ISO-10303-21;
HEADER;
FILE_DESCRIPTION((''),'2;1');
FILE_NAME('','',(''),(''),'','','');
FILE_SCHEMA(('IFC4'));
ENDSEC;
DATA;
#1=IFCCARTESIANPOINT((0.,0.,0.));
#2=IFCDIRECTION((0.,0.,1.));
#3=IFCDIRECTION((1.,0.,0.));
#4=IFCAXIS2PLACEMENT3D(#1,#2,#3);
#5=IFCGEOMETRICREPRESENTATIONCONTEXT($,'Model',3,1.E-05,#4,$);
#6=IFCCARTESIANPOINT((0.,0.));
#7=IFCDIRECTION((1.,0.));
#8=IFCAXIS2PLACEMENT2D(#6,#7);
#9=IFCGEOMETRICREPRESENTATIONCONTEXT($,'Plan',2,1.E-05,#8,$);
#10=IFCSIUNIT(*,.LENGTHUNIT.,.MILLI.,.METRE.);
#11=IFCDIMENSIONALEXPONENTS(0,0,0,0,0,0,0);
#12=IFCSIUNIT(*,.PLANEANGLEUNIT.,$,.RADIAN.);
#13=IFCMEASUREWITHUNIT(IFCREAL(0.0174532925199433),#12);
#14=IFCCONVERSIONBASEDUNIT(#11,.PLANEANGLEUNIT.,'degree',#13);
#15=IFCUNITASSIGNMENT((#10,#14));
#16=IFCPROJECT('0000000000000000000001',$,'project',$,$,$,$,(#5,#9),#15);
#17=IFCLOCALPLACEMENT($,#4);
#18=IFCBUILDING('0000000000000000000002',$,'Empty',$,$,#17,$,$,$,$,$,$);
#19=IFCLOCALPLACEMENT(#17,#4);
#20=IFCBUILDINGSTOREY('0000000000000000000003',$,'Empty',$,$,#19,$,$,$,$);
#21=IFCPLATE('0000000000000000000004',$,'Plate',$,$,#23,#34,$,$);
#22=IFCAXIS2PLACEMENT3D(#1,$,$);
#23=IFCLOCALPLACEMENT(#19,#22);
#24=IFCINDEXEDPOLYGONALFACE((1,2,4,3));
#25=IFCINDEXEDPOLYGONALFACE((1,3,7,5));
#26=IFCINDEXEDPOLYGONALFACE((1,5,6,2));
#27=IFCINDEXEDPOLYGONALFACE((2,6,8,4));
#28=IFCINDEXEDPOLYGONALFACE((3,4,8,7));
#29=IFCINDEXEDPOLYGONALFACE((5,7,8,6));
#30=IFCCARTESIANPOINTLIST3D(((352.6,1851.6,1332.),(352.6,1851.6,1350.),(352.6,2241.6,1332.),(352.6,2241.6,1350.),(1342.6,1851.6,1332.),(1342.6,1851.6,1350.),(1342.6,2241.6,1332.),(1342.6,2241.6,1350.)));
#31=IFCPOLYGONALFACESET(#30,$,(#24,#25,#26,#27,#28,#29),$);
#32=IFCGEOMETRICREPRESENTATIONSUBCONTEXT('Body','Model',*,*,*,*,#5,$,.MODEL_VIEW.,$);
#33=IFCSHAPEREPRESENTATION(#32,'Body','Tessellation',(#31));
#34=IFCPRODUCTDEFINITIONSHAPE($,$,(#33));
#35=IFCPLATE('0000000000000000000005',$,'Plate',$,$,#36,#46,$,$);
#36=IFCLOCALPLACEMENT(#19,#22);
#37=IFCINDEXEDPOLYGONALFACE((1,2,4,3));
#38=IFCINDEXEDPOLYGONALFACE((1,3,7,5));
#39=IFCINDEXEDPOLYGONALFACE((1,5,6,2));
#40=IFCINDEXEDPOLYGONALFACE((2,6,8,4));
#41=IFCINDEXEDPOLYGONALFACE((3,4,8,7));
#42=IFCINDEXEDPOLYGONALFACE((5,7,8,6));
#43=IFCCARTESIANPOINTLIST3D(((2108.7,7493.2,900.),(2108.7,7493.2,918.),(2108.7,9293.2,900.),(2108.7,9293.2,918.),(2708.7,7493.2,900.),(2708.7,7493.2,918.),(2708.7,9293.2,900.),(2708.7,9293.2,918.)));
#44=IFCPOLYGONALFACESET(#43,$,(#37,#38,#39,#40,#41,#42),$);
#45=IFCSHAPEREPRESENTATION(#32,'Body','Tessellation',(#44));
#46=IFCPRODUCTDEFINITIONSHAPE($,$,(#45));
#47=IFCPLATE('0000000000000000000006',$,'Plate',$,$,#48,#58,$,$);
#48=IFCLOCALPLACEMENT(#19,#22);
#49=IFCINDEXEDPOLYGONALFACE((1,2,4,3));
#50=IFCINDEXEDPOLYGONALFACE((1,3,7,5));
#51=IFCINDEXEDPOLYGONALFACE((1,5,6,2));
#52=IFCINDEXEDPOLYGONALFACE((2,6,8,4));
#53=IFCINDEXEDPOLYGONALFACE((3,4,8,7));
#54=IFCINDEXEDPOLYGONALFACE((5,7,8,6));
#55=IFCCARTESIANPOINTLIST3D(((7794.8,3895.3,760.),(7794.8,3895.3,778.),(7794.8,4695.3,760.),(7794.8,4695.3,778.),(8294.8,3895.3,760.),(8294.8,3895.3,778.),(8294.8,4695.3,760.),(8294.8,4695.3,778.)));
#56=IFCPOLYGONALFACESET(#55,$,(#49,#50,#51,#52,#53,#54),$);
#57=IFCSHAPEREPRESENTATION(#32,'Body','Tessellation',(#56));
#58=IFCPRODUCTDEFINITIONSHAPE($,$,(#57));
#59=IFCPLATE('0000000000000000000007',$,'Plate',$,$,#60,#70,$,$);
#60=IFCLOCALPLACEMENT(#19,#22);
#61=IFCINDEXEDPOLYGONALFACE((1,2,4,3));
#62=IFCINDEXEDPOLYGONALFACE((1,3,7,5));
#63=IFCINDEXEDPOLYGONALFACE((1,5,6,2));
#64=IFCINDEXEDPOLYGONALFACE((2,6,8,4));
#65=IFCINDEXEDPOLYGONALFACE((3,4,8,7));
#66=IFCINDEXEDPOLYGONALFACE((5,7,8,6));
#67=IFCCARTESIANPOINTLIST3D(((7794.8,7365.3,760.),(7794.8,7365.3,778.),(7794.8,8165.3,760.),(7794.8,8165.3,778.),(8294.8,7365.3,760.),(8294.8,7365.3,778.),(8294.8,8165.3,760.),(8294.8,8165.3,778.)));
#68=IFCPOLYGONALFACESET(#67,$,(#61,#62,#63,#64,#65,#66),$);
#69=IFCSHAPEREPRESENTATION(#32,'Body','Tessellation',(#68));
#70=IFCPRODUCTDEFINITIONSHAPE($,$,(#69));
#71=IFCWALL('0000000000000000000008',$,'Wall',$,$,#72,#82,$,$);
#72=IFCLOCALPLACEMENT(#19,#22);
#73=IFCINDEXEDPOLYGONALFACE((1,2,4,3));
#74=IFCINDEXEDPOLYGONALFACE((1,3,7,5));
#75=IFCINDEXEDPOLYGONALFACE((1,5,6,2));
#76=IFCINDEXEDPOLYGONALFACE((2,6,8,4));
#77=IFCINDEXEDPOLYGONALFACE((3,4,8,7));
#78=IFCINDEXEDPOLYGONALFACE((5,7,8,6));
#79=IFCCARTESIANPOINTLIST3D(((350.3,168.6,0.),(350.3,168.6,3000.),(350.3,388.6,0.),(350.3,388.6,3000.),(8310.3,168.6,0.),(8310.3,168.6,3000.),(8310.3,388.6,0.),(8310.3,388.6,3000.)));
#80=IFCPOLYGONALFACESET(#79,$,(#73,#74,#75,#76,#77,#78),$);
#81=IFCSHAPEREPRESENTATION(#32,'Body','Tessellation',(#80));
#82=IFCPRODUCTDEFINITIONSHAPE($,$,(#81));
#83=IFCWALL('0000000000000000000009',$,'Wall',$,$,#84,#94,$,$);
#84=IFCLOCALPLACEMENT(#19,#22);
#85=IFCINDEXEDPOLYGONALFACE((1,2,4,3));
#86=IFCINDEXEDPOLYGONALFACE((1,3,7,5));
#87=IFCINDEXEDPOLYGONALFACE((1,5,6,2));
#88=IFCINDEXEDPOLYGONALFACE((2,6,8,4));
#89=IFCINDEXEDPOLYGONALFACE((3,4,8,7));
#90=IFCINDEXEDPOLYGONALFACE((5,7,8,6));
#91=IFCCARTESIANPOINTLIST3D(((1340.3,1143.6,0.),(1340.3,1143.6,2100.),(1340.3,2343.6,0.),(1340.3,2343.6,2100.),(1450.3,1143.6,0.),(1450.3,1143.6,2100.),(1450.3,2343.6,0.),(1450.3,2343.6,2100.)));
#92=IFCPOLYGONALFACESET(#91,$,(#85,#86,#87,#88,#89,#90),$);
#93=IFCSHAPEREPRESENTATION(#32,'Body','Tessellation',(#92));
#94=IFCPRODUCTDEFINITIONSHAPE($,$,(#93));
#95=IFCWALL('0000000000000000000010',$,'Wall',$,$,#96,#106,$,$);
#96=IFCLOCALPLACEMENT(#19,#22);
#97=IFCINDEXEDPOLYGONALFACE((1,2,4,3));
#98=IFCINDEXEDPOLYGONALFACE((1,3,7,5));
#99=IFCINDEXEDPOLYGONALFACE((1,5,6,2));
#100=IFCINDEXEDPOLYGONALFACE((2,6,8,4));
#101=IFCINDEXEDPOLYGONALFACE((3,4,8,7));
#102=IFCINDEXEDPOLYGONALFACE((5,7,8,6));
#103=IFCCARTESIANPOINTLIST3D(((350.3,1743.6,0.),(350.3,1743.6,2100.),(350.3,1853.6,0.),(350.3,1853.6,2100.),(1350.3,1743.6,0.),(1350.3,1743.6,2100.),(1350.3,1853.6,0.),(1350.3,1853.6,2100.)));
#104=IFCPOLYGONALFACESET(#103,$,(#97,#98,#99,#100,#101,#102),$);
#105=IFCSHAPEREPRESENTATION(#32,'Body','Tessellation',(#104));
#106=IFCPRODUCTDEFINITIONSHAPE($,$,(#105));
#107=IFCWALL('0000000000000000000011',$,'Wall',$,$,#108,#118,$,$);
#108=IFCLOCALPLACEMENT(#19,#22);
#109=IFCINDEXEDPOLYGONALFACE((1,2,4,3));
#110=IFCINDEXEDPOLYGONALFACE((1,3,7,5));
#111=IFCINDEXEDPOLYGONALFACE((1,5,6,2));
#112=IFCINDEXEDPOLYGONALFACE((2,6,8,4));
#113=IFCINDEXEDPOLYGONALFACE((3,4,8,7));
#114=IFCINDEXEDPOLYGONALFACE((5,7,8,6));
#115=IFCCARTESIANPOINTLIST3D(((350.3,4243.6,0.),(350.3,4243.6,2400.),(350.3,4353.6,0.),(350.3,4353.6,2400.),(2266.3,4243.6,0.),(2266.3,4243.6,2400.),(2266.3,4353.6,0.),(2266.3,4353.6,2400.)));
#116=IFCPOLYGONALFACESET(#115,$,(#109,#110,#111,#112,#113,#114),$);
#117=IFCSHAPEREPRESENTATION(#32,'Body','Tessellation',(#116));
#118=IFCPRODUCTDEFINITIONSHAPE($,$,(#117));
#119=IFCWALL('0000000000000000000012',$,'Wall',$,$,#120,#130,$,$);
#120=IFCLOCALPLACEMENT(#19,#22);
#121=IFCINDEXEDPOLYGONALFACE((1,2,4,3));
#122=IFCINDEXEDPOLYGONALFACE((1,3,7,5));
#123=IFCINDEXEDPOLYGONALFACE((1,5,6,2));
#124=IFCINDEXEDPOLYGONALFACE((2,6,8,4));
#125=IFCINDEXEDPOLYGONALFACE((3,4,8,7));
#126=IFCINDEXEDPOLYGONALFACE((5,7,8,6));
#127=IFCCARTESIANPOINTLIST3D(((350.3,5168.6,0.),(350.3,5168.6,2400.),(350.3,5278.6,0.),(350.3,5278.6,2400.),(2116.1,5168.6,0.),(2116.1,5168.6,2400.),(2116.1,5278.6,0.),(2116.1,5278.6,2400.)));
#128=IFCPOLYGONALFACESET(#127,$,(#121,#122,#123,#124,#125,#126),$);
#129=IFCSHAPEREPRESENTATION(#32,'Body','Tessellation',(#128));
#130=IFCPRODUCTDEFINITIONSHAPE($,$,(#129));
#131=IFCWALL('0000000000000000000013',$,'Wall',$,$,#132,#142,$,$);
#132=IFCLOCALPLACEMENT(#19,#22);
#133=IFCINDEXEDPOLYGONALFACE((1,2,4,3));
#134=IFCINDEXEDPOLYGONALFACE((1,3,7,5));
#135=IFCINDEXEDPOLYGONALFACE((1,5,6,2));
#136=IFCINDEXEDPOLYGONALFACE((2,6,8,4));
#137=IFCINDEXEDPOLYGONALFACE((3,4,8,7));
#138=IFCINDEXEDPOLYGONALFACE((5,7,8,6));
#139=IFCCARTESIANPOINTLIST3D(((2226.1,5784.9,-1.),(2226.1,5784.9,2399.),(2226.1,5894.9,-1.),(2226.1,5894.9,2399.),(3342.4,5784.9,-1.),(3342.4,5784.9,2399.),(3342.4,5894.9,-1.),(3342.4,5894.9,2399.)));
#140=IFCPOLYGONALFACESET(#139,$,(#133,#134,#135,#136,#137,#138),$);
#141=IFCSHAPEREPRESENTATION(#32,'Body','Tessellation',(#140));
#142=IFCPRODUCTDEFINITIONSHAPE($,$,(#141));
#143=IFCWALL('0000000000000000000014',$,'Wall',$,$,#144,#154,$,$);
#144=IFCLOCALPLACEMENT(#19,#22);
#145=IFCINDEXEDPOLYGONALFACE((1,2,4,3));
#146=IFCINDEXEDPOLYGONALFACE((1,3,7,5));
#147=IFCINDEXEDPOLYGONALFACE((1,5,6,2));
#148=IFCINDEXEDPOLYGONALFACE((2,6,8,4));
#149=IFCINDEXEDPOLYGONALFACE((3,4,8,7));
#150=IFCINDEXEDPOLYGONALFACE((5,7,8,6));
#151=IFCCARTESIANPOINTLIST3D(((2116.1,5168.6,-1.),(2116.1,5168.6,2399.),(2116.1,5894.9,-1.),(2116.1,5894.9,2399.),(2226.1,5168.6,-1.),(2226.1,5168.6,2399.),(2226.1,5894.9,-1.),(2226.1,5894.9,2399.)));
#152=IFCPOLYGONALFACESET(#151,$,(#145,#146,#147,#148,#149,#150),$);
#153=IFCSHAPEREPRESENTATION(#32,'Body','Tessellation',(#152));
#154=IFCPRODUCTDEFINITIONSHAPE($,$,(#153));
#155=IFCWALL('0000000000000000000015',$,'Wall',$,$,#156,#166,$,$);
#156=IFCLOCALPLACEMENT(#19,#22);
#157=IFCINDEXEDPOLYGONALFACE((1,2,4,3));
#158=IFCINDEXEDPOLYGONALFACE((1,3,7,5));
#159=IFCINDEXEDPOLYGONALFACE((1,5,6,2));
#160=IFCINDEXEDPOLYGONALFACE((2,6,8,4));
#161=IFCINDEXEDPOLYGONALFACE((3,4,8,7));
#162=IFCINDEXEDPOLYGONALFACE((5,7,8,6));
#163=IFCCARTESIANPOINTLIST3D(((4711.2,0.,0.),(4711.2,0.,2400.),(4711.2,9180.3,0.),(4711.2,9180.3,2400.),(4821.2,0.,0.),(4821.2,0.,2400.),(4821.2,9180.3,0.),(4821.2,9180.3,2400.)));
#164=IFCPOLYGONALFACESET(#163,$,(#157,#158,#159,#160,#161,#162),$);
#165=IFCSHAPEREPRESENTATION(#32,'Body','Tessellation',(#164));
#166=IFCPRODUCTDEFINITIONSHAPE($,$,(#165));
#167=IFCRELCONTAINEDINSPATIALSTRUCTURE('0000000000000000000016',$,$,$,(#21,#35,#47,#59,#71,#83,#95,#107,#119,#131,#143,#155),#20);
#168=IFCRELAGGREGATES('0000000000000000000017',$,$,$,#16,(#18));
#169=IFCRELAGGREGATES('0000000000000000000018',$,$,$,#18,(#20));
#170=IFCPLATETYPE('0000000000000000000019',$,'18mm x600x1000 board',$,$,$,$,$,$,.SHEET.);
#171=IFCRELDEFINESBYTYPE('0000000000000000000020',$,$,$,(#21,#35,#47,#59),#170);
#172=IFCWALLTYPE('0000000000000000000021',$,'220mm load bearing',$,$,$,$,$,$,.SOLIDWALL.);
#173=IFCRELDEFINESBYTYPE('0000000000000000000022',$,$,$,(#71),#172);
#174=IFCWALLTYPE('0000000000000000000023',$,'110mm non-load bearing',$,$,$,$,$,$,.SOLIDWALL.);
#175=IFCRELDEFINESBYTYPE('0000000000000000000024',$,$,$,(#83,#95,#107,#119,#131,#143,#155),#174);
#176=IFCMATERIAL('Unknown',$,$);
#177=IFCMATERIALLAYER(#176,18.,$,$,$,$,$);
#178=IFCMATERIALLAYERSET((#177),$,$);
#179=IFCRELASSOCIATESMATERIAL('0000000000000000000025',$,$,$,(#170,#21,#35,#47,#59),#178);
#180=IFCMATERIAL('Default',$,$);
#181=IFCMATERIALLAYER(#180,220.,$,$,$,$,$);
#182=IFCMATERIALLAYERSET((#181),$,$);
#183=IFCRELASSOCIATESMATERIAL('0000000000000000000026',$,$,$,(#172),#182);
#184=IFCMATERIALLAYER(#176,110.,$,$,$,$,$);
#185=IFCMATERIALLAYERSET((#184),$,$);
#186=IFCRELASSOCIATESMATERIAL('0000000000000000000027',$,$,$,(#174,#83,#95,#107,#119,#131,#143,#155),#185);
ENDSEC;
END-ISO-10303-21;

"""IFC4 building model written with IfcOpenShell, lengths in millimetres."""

from ifc_helpers import new_model, entity, si_unit, converted_unit, frame, origin_with_axes, origin_2d_with_axis, place, context, subcontext, project, spatial, polyline, line, indexed_curve, outline, extrude, material, layer, layer_set, layer_usage, type_object, element, save


model = new_model("IFC4")

# Units and contexts
model_context = context("Model", 3, precision=1e-05, world=origin_with_axes())
plan_context = context("Plan", 2, precision=1e-05, world=origin_2d_with_axis())
body_context = subcontext(model_context, "Body", "Model", "MODEL_VIEW")
ifc_project = project(units=[si_unit("LENGTHUNIT", "METRE", prefix="MILLI"), converted_unit("PLANEANGLEUNIT", "degree", entity("IfcReal", 0.0174532925199433), si_unit("PLANEANGLEUNIT", "RADIAN"), dimensions=[0, 0, 0, 0, 0, 0, 0])], contexts=[model_context, plan_context])

# Building, storey
building_placement = place(None, origin_with_axes())
building = spatial("IfcBuilding", under=ifc_project, at=building_placement, Name="Empty")
storey_placement = place(building_placement, origin_with_axes())
storey = spatial("IfcBuildingStorey", under=building, at=storey_placement, Name="Empty")

# Shared definitions
ifc_material_1 = material(Name="Unknown")

# Plates
ifc_layer_1 = layer(ifc_material_1, 18.0)
ifc_layer_set_1 = layer_set([ifc_layer_1])
plate_type = type_object("IfcPlateType", Name="18mm x600x1000 board", PredefinedType="SHEET", material=ifc_layer_set_1)
ifc_layer_usage_1 = layer_usage(ifc_layer_set_1, "AXIS3", "POSITIVE", 0.0)
plate_1_placement = place(storey_placement, frame((352.6, 1851.6, 1332.0), z_axis=(0.0, 0.0, 1.0), x_axis=(1.0, 0.000001, 0.0)))
element("IfcPlate", 1, at=plate_1_placement, inside=storey, type_object=plate_type, material=ifc_layer_usage_1, Name="Plate", context=body_context, shape_type="SweptSolid", body=[
    extrude(outline(indexed_curve([(0.0, 390.0), (0.0, 0.0), (990.0, 0.0), (990.0, 390.0)], segments=[line(4, 1), line(1, 2), line(2, 3), line(3, 4)], self_intersect=False)), None, (0.0, 0.0, 1.0), 18.0),
])
ifc_layer_usage_2 = layer_usage(ifc_layer_set_1, "AXIS3", "POSITIVE", 0.0)
plate_2_placement = place(storey_placement, frame((2108.7, 7493.2, 900.0), z_axis=(0.0, 0.0, 1.0), x_axis=(1.0, 0.000001, 0.0)))
element("IfcPlate", 2, at=plate_2_placement, inside=storey, type_object=plate_type, material=ifc_layer_usage_2, Name="Plate", context=body_context, shape_type="SweptSolid", body=[
    extrude(outline(indexed_curve([(0.0, 1800.0), (600.0, 1800.0), (600.0, 0.0), (0.0, 0.0)], segments=[line(3, 2), line(2, 1), line(1, 4), line(4, 3)], self_intersect=False)), None, (0.0, 0.0, 1.0), 18.0),
])
ifc_layer_usage_3 = layer_usage(ifc_layer_set_1, "AXIS3", "POSITIVE", 0.0)
plate_3_placement = place(storey_placement, frame((7794.8, 4695.3, 760.0), z_axis=(0.0, 0.0, 1.0), x_axis=(0.000002, -1.0, 0.0)))
element("IfcPlate", 3, at=plate_3_placement, inside=storey, type_object=plate_type, material=ifc_layer_usage_3, Name="Plate", context=body_context, shape_type="SweptSolid", body=[
    extrude(outline(indexed_curve([(0.0, 500.0), (0.0, 0.0), (800.0, 0.0), (800.0, 500.0)], segments=[line(3, 2), line(2, 1), line(1, 4), line(4, 3)], self_intersect=False)), None, (0.0, 0.0, 1.0), 18.0),
])
ifc_layer_usage_4 = layer_usage(ifc_layer_set_1, "AXIS3", "POSITIVE", 0.0)
plate_4_placement = place(storey_placement, frame((7794.8, 8165.3, 760.0), z_axis=(0.0, 0.0, 1.0), x_axis=(0.000002, -1.0, 0.0)))
element("IfcPlate", 4, at=plate_4_placement, inside=storey, type_object=plate_type, material=ifc_layer_usage_4, Name="Plate", context=body_context, shape_type="SweptSolid", body=[
    extrude(outline(indexed_curve([(0.0, 500.0), (0.0, 0.0), (800.0, 0.0), (800.0, 500.0)], segments=[line(3, 2), line(2, 1), line(1, 4), line(4, 3)], self_intersect=False)), None, (0.0, 0.0, 1.0), 18.0),
])

# Walls
ifc_material_2 = material(Name="Default")
ifc_layer_2 = layer(ifc_material_2, 220.0)
ifc_layer_set_2 = layer_set([ifc_layer_2])
wall_type_1 = type_object("IfcWallType", Name="220mm load bearing", PredefinedType="SOLIDWALL", material=ifc_layer_set_2)
wall_1_placement = place(storey_placement, frame((350.3, 168.6, 0.0), z_axis=(0.0, 0.0, 1.0), x_axis=(1.0, 0.0, 0.0)))
element("IfcWall", 5, at=wall_1_placement, inside=storey, type_object=wall_type_1, Name="Wall", context=body_context, shape_type="SweptSolid", body=[
    extrude(outline(polyline([(-3980.0, -110.0), (3980.0, -110.0), (3980.0, 110.0), (-3980.0, 110.0), (-3980.0, -110.0)])), frame((3980.0, 110.0, 0.0), z_axis=(0.0, 0.0, -1.0), x_axis=(-1.0, 0.0, 0.0)), (0.0, 0.0, -1.0), 3000.0),
])
ifc_layer_3 = layer(ifc_material_1, 110.0)
ifc_layer_set_3 = layer_set([ifc_layer_3])
ifc_layer_usage_5 = layer_usage(ifc_layer_set_3, "AXIS2", "POSITIVE", 0.0)
wall_type_2 = type_object("IfcWallType", Name="110mm non-load bearing", PredefinedType="SOLIDWALL", material=ifc_layer_set_3)
wall_2_placement = place(storey_placement, frame((1450.3, 1143.6, 0.0), z_axis=(0.0, 0.0, 1.0), x_axis=(0.0, 1.0, 0.0)))
element("IfcWall", 6, at=wall_2_placement, inside=storey, type_object=wall_type_2, material=ifc_layer_usage_5, Name="Wall", context=body_context, shape_type="SweptSolid", body=[
    extrude(outline(indexed_curve([(0.0, 0.0), (0.0, 110.0), (1200.0, 110.0), (1200.0, 0.0), (0.0, 0.0)], self_intersect=False)), origin_with_axes(), (0.0, 0.0, 1.0), 2100.0),
])
ifc_layer_usage_6 = layer_usage(ifc_layer_set_3, "AXIS2", "POSITIVE", 0.0)
wall_3_placement = place(storey_placement, frame((350.3, 1743.6, 0.0), z_axis=(0.0, 0.0, 1.0), x_axis=(1.0, 0.000001, 0.0)))
element("IfcWall", 7, at=wall_3_placement, inside=storey, type_object=wall_type_2, material=ifc_layer_usage_6, Name="Wall", context=body_context, shape_type="SweptSolid", body=[
    extrude(outline(indexed_curve([(0.0, 0.0), (0.0, 110.0), (1000.0, 110.0), (1000.0, 0.0), (0.0, 0.0)], self_intersect=False)), origin_with_axes(), (0.0, 0.0, 1.0), 2100.0),
])
ifc_layer_usage_7 = layer_usage(ifc_layer_set_3, "AXIS2", "POSITIVE", 0.0)
wall_4_placement = place(storey_placement, frame((350.3, 4243.6, 0.0), z_axis=(0.0, 0.0, 1.0), x_axis=(1.0, 0.0, 0.0)))
element("IfcWall", 8, at=wall_4_placement, inside=storey, type_object=wall_type_2, material=ifc_layer_usage_7, Name="Wall", context=body_context, shape_type="SweptSolid", body=[
    extrude(outline(indexed_curve([(0.0, 0.0), (0.0, 110.0), (1916.0, 110.0), (1916.0, 0.0), (0.0, 0.0)], self_intersect=False)), origin_with_axes(), (0.0, 0.0, 1.0), 2400.0),
])
ifc_layer_usage_8 = layer_usage(ifc_layer_set_3, "AXIS2", "POSITIVE", 0.0)
wall_5_placement = place(storey_placement, frame((350.3, 5168.6, 0.0), z_axis=(0.0, 0.0, 1.0), x_axis=(1.0, 0.0, 0.0)))
element("IfcWall", 9, at=wall_5_placement, inside=storey, type_object=wall_type_2, material=ifc_layer_usage_8, Name="Wall", context=body_context, shape_type="SweptSolid", body=[
    extrude(outline(indexed_curve([(0.0, 0.0), (0.0, 110.0), (1765.8, 110.0), (1765.8, 0.0), (0.0, 0.0)], self_intersect=False)), origin_with_axes(), (0.0, 0.0, 1.0), 2400.0),
])
ifc_layer_usage_9 = layer_usage(ifc_layer_set_3, "AXIS2", "POSITIVE", 0.0)
wall_6_placement = place(storey_placement, frame((2226.1, 5784.9, -1.0), z_axis=(0.0, 0.0, 1.0), x_axis=(1.0, 0.0, 0.0)))
element("IfcWall", 10, at=wall_6_placement, inside=storey, type_object=wall_type_2, material=ifc_layer_usage_9, Name="Wall", context=body_context, shape_type="SweptSolid", body=[
    extrude(outline(indexed_curve([(0.0, 0.0), (0.0, 110.0), (1116.2, 110.0), (1116.2, 0.0), (0.0, 0.0)], self_intersect=False)), origin_with_axes(), (0.0, 0.0, 1.0), 2400.0),
])
ifc_layer_usage_10 = layer_usage(ifc_layer_set_3, "AXIS2", "POSITIVE", 0.0)
wall_7_placement = place(storey_placement, frame((2226.1, 5168.6, -1.0), z_axis=(0.0, 0.0, 1.0), x_axis=(0.0, 1.0, 0.0)))
element("IfcWall", 11, at=wall_7_placement, inside=storey, type_object=wall_type_2, material=ifc_layer_usage_10, Name="Wall", context=body_context, shape_type="SweptSolid", body=[
    extrude(outline(indexed_curve([(0.0, 0.0), (0.0, 110.0), (726.3, 110.0), (726.3, 0.0), (0.0, 0.0)], self_intersect=False)), origin_with_axes(), (0.0, 0.0, 1.0), 2400.0),
])
ifc_layer_usage_11 = layer_usage(ifc_layer_set_3, "AXIS2", "POSITIVE", 0.0)
wall_8_placement = place(storey_placement, frame((4711.2, 9180.3, 0.0), z_axis=(0.0, 0.0, 1.0), x_axis=(0.000001, -1.0, 0.0)))
element("IfcWall", 12, at=wall_8_placement, inside=storey, type_object=wall_type_2, material=ifc_layer_usage_11, Name="Wall", context=body_context, shape_type="SweptSolid", body=[
    extrude(outline(indexed_curve([(0.0, 0.0), (0.0, 110.0), (9180.3, 110.0), (9180.3, 0.0), (0.0, 0.0)], self_intersect=False)), origin_with_axes(), (0.0, 0.0, 1.0), 2400.0),
])

save(model, "model.ifc")
